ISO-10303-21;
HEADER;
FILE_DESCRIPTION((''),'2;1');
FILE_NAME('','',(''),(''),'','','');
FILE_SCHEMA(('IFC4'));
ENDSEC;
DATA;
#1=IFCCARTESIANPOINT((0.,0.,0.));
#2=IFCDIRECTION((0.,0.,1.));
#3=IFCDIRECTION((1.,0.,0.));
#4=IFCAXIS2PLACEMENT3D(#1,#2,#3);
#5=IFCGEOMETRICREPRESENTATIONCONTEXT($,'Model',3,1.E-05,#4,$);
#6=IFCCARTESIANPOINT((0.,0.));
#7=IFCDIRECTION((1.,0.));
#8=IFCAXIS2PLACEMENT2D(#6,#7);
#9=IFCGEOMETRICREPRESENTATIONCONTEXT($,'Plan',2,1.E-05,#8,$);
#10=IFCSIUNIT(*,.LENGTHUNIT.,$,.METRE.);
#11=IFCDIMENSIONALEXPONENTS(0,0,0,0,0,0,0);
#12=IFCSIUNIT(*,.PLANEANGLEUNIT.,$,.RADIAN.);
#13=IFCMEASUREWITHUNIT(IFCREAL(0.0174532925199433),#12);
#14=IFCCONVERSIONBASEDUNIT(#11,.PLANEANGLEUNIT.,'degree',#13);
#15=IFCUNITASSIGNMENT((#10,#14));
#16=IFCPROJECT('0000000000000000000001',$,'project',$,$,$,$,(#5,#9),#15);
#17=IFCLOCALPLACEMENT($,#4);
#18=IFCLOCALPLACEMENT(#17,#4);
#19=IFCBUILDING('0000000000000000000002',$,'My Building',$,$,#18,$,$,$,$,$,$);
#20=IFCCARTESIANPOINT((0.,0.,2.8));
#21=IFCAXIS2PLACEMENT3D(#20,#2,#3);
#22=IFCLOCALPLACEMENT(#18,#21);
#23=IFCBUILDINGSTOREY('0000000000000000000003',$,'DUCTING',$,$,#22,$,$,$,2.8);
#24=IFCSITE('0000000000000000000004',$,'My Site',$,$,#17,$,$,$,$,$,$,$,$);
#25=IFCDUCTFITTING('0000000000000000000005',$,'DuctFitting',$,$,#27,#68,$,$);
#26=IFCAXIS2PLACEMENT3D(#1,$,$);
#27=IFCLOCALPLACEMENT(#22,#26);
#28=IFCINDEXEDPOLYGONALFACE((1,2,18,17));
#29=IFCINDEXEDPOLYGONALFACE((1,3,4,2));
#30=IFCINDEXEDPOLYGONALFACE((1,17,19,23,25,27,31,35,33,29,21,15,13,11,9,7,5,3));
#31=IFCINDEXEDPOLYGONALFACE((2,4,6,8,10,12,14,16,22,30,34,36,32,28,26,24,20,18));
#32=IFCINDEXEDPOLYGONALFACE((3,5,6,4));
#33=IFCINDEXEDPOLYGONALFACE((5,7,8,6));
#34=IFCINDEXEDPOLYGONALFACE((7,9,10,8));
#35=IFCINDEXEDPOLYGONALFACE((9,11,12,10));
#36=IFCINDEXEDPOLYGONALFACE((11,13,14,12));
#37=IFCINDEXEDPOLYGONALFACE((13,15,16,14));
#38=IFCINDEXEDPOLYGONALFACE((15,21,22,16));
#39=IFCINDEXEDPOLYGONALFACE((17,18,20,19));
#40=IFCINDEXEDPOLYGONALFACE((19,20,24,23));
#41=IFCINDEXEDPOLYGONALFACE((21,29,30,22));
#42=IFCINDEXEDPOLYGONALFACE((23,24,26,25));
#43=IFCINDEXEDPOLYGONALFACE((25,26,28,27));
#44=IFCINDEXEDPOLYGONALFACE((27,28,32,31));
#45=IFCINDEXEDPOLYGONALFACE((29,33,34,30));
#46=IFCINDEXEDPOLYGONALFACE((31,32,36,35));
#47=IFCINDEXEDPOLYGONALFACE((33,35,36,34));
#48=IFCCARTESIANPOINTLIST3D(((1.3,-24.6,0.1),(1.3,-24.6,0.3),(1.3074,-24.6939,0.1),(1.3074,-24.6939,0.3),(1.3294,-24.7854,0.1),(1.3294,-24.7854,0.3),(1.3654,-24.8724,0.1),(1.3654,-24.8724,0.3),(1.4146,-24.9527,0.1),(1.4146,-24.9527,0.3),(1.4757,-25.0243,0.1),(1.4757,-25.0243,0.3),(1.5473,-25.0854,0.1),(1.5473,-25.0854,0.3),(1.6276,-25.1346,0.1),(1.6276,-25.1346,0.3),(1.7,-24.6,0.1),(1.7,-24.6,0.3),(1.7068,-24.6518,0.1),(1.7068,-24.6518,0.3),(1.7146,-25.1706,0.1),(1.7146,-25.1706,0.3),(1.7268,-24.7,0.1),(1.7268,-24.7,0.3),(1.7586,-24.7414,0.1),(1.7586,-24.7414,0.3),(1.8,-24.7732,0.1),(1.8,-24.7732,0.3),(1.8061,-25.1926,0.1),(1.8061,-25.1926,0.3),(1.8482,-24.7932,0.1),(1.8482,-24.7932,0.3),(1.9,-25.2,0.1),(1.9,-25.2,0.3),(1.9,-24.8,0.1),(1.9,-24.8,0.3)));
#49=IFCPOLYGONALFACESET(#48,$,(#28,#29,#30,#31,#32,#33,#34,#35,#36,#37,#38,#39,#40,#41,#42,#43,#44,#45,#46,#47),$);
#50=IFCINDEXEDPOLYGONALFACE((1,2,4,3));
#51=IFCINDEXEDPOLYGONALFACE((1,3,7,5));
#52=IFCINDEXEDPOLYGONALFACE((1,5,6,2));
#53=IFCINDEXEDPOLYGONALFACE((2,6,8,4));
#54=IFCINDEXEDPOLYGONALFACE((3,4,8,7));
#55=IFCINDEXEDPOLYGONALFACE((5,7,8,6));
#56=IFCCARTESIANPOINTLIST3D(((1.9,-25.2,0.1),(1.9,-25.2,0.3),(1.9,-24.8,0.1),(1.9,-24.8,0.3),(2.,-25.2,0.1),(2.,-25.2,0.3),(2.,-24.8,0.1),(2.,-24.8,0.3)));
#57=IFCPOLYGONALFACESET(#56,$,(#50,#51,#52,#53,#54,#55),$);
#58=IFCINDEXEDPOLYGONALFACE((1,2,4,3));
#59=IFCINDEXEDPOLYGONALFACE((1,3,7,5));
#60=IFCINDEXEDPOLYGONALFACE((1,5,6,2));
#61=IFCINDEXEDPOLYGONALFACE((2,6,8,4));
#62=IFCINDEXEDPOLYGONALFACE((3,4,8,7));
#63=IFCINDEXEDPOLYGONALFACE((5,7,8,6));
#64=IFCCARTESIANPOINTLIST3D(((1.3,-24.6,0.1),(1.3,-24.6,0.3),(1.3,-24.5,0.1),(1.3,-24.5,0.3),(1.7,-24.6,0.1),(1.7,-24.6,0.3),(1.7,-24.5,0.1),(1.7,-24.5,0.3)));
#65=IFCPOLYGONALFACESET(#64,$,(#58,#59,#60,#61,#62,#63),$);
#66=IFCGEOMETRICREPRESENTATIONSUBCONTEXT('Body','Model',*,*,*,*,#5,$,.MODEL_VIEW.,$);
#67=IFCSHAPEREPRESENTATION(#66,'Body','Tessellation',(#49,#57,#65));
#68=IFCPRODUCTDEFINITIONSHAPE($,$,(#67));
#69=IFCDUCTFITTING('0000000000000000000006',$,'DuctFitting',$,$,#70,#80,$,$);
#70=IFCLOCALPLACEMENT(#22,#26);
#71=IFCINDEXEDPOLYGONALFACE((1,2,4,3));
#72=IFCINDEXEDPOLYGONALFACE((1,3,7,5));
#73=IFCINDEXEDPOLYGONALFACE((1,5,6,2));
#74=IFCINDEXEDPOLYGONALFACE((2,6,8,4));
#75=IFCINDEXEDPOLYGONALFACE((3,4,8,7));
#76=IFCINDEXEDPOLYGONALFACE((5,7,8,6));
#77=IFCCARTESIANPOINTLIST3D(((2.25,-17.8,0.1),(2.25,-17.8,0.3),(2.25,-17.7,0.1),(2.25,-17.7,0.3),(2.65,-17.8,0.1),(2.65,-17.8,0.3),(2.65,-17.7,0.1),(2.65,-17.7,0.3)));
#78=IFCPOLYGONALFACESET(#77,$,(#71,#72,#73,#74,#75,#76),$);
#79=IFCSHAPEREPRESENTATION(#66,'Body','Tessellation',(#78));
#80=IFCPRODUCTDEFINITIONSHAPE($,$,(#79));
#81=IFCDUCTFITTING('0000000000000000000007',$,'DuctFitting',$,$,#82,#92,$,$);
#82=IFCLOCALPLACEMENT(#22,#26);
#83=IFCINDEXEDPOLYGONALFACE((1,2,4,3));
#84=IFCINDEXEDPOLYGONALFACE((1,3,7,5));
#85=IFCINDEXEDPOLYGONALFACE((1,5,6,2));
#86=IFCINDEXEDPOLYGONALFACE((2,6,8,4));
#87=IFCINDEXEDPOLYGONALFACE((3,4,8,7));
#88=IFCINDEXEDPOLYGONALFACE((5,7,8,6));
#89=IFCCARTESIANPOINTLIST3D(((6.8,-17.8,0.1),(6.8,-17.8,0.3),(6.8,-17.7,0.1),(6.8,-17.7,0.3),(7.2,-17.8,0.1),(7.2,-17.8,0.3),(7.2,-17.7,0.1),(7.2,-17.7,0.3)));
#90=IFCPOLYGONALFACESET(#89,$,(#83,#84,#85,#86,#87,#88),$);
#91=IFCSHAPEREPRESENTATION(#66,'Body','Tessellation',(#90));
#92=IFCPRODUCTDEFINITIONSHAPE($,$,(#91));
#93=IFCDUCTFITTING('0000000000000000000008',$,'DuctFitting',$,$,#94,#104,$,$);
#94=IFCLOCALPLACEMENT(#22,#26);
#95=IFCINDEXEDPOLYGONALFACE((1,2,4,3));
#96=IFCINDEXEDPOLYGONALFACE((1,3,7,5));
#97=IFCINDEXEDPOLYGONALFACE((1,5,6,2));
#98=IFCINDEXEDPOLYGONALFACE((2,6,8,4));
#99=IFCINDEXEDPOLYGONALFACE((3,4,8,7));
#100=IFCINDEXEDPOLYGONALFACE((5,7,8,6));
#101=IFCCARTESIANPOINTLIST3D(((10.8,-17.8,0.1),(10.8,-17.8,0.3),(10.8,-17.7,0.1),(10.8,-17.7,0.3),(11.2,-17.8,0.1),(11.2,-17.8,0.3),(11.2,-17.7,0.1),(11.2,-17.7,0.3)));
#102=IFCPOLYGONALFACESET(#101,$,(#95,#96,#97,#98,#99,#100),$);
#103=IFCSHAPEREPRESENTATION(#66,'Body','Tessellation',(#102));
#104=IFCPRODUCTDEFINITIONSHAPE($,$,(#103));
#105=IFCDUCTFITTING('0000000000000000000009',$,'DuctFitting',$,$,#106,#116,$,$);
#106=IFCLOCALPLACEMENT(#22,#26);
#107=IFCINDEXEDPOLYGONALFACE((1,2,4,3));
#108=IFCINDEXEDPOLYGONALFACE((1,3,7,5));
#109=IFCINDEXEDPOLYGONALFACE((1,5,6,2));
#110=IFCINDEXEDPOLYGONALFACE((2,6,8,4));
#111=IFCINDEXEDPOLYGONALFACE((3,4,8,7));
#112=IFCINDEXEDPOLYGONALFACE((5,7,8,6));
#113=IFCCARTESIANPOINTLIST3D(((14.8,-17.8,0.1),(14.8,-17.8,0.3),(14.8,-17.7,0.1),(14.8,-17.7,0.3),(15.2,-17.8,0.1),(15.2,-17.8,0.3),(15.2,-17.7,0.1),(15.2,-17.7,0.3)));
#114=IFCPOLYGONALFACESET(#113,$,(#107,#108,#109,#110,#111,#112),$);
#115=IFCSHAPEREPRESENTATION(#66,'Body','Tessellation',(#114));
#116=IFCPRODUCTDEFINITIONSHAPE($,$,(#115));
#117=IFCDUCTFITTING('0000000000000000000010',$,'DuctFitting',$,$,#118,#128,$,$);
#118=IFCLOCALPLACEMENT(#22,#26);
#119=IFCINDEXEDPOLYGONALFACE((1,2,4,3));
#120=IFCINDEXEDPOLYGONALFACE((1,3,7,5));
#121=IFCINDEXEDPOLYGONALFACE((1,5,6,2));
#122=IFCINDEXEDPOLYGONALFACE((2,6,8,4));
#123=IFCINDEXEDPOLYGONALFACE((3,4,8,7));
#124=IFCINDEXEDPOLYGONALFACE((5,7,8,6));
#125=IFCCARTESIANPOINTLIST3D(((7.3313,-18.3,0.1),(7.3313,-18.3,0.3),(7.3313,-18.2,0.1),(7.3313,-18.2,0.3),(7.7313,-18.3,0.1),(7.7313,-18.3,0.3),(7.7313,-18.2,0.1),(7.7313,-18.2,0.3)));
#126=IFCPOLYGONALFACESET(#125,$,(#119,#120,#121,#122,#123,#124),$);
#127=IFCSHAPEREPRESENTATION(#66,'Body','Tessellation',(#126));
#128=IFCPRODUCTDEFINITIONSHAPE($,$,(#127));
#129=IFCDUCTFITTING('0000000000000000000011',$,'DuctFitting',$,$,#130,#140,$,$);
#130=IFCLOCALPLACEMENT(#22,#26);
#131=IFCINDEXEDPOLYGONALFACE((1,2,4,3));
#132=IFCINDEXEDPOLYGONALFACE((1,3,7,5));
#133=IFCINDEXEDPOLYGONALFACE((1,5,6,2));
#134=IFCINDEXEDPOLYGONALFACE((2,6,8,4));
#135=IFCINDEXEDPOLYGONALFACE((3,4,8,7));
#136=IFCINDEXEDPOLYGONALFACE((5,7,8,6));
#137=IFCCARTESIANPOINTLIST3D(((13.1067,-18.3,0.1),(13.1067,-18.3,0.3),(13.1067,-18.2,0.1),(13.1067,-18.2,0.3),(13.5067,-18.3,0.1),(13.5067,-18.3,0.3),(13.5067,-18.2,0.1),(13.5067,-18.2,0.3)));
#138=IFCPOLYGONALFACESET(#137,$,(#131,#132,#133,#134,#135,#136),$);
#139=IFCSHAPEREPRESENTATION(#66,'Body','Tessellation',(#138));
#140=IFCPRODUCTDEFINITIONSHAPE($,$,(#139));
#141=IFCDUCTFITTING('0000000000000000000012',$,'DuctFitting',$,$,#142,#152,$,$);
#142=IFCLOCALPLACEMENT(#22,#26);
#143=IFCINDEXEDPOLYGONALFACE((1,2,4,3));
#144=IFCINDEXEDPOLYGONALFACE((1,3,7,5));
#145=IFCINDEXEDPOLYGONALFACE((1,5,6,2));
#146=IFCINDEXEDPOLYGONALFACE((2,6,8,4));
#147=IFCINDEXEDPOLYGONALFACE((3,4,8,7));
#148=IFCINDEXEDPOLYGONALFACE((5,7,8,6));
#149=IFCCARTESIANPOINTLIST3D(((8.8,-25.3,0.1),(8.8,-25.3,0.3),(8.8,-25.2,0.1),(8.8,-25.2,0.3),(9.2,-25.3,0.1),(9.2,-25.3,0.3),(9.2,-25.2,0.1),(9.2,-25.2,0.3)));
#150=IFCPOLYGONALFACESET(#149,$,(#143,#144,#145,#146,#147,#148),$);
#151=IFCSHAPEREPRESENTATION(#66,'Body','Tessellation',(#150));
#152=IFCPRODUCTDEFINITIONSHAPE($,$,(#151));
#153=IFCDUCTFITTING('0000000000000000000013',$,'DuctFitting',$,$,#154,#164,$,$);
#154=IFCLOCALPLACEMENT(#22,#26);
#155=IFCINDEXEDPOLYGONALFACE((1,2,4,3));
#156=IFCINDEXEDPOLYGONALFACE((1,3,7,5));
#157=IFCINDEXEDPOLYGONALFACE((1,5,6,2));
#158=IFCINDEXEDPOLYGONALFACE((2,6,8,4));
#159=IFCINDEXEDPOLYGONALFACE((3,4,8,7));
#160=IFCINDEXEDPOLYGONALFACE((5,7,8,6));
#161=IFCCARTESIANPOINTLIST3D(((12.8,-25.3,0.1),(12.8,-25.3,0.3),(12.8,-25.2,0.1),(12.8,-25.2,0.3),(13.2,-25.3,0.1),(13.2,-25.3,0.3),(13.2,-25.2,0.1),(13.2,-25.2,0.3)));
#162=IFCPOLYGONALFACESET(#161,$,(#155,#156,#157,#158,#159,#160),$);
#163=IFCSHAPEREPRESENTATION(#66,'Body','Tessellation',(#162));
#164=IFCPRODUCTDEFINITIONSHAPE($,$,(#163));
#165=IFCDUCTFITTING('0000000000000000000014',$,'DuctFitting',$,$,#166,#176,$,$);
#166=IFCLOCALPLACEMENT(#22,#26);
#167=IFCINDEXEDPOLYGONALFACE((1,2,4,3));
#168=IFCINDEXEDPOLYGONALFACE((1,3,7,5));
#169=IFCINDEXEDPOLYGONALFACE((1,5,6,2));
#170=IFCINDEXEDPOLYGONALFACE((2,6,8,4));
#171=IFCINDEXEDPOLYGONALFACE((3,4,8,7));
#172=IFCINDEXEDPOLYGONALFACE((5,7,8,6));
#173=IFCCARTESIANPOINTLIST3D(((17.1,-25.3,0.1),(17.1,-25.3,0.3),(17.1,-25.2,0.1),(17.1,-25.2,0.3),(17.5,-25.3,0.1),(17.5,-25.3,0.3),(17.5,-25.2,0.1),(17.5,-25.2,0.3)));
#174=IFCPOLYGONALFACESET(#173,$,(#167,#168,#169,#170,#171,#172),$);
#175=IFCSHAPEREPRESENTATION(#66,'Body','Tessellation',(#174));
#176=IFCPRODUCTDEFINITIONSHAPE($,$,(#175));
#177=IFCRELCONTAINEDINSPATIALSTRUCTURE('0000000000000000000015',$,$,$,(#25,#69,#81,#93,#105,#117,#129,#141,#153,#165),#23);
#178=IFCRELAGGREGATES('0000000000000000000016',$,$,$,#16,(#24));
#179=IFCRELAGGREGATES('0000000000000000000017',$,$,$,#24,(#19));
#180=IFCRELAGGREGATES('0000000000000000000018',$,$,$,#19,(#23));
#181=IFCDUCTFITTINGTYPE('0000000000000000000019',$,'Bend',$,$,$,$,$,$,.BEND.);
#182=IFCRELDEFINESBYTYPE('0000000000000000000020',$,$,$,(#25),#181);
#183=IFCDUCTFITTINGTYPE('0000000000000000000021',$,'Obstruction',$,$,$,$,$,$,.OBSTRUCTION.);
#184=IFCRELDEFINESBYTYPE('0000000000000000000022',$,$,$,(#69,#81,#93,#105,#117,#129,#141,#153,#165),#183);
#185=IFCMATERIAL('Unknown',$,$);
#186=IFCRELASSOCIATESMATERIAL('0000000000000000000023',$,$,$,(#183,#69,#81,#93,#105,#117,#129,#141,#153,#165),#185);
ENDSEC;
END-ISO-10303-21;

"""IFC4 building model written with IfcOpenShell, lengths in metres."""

from ifc_helpers import new_model, entity, si_unit, converted_unit, frame, origin_with_axes, origin_2d_with_axis, place, context, subcontext, project, spatial, line, arc, indexed_curve, rectangle, outline, extrude, source, transform, mapped, material, material_profile, profile_set, profile_usage, type_object, type_shapes, element, save


model = new_model("IFC4")

# Units and contexts
model_context = context("Model", 3, precision=1e-05, world=origin_with_axes())
plan_context = context("Plan", 2, precision=1e-05, world=origin_2d_with_axis())
body_context = subcontext(model_context, "Body", "Model", "MODEL_VIEW")
ifc_project = project(units=[si_unit("LENGTHUNIT", "METRE"), converted_unit("PLANEANGLEUNIT", "degree", entity("IfcReal", 0.0174532925199433), si_unit("PLANEANGLEUNIT", "RADIAN"), dimensions=[0, 0, 0, 0, 0, 0, 0])], contexts=[model_context, plan_context])

# Site, building, storey
site_placement = place(None, origin_with_axes())
site = spatial("IfcSite", under=ifc_project, at=site_placement, Name="My Site")
building_placement = place(site_placement, origin_with_axes())
building = spatial("IfcBuilding", under=site, at=building_placement, Name="My Building")
storey_placement = place(building_placement, frame((0.0, 0.0, 2.8), z_axis=(0.0, 0.0, 1.0), x_axis=(1.0, 0.0, 0.0)))
storey = spatial("IfcBuildingStorey", under=building, at=storey_placement, Name="DUCTING", Elevation=2.8)

# Shared definitions
ifc_material = material(Name="Unknown")
ifc_material_profile = material_profile(ifc_material, rectangle(XDim=0.4, YDim=0.2))
ifc_profile_set = profile_set([ifc_material_profile])

# Duct fittings
duct_fitting_type_1 = type_object("IfcDuctFittingType", Name="Bend", PredefinedType="BEND")
shared_shape = source(origin_with_axes(), body_context, "Body", "SweptSolid", [
    extrude(outline(indexed_curve([(-0.2, 0.0), (-0.2586, 0.1414), (-0.4, 0.2), (-0.4, 0.6), (0.0243, 0.4243), (0.2, 0.0)], segments=[arc(1, 2, 3), line(3, 4), arc(4, 5, 6), line(6, 1)])), frame((0.0, -0.1, 0.1), z_axis=(0.0, -1.0, 0.0), x_axis=(1.0, 0.0, 0.0)), (0.0, 0.0, -1.0), 0.2),
    extrude(rectangle(XDim=0.4, YDim=0.2), origin_with_axes(), (0.0, 0.0, 1.0), 0.1),
    extrude(rectangle(XDim=0.4, YDim=0.2), frame((-0.4, 0.0, 0.5), z_axis=(-1.0, 0.0, 0.0), x_axis=(0.0, 0.0, -1.0)), (0.0, 0.0, 1.0), 0.1),
])
type_shapes(duct_fitting_type_1, [shared_shape])
for number, where, z_axis, x_axis, name in (
    (1, (2.0, -25.0, 0.2), (-1.0, 0.0, 0.0), (0.0, -1.0, 0.0), "DuctFitting"),
):
    element("IfcDuctFitting", number, at=place(storey_placement, frame(where, z_axis=z_axis, x_axis=x_axis)), inside=storey, type_object=duct_fitting_type_1, Name=name, context=body_context, shape_type="MappedRepresentation", body=[
        mapped(shared_shape, transform((0.0, 0.0, 0.0), x_axis=(1.0, 0.0, 0.0), y_axis=(0.0, 1.0, 0.0), z_axis=(0.0, 0.0, 1.0), scale=1.0)),
    ])
ifc_profile_usage_1 = profile_usage(ifc_profile_set)
duct_fitting_type_2 = type_object("IfcDuctFittingType", Name="Obstruction", PredefinedType="OBSTRUCTION", material=ifc_profile_set)
duct_fitting_1_placement = place(storey_placement, frame((2.45, -17.8, 0.2), z_axis=(0.0, 1.0, 0.0), x_axis=(-1.0, 0.0, 0.0)))
element("IfcDuctFitting", 2, at=duct_fitting_1_placement, inside=storey, type_object=duct_fitting_type_2, material=ifc_profile_usage_1, Name="DuctFitting", context=body_context, shape_type="SweptSolid", body=[
    extrude(rectangle(XDim=0.4, YDim=0.2), origin_with_axes(), (0.0, 0.0, 1.0), 0.1),
])
ifc_profile_usage_2 = profile_usage(ifc_profile_set)
duct_fitting_2_placement = place(storey_placement, frame((7.0, -17.8, 0.2), z_axis=(0.0, 1.0, 0.0), x_axis=(-1.0, 0.0, 0.0)))
element("IfcDuctFitting", 3, at=duct_fitting_2_placement, inside=storey, type_object=duct_fitting_type_2, material=ifc_profile_usage_2, Name="DuctFitting", context=body_context, shape_type="SweptSolid", body=[
    extrude(rectangle(XDim=0.4, YDim=0.2), origin_with_axes(), (0.0, 0.0, 1.0), 0.1),
])
ifc_profile_usage_3 = profile_usage(ifc_profile_set)
duct_fitting_3_placement = place(storey_placement, frame((11.0, -17.8, 0.2), z_axis=(0.0, 1.0, 0.0), x_axis=(-1.0, 0.0, 0.0)))
element("IfcDuctFitting", 4, at=duct_fitting_3_placement, inside=storey, type_object=duct_fitting_type_2, material=ifc_profile_usage_3, Name="DuctFitting", context=body_context, shape_type="SweptSolid", body=[
    extrude(rectangle(XDim=0.4, YDim=0.2), origin_with_axes(), (0.0, 0.0, 1.0), 0.1),
])
ifc_profile_usage_4 = profile_usage(ifc_profile_set)
duct_fitting_4_placement = place(storey_placement, frame((15.0, -17.8, 0.2), z_axis=(0.0, 1.0, 0.0), x_axis=(-1.0, 0.0, 0.0)))
element("IfcDuctFitting", 5, at=duct_fitting_4_placement, inside=storey, type_object=duct_fitting_type_2, material=ifc_profile_usage_4, Name="DuctFitting", context=body_context, shape_type="SweptSolid", body=[
    extrude(rectangle(XDim=0.4, YDim=0.2), origin_with_axes(), (0.0, 0.0, 1.0), 0.1),
])
ifc_profile_usage_5 = profile_usage(ifc_profile_set)
duct_fitting_5_placement = place(storey_placement, frame((7.5313, -18.2, 0.2), z_axis=(0.0, -1.0, 0.0), x_axis=(1.0, 0.0, 0.0)))
element("IfcDuctFitting", 6, at=duct_fitting_5_placement, inside=storey, type_object=duct_fitting_type_2, material=ifc_profile_usage_5, Name="DuctFitting", context=body_context, shape_type="SweptSolid", body=[
    extrude(rectangle(XDim=0.4, YDim=0.2), origin_with_axes(), (0.0, 0.0, 1.0), 0.1),
])
ifc_profile_usage_6 = profile_usage(ifc_profile_set)
duct_fitting_6_placement = place(storey_placement, frame((13.3067, -18.2, 0.2), z_axis=(0.0, -1.0, 0.0), x_axis=(1.0, 0.0, 0.0)))
element("IfcDuctFitting", 7, at=duct_fitting_6_placement, inside=storey, type_object=duct_fitting_type_2, material=ifc_profile_usage_6, Name="DuctFitting", context=body_context, shape_type="SweptSolid", body=[
    extrude(rectangle(XDim=0.4, YDim=0.2), origin_with_axes(), (0.0, 0.0, 1.0), 0.1),
])
ifc_profile_usage_7 = profile_usage(ifc_profile_set)
duct_fitting_7_placement = place(storey_placement, frame((9.0, -25.2, 0.2), z_axis=(0.0, -1.0, 0.0), x_axis=(1.0, 0.0, 0.0)))
element("IfcDuctFitting", 8, at=duct_fitting_7_placement, inside=storey, type_object=duct_fitting_type_2, material=ifc_profile_usage_7, Name="DuctFitting", context=body_context, shape_type="SweptSolid", body=[
    extrude(rectangle(XDim=0.4, YDim=0.2), origin_with_axes(), (0.0, 0.0, 1.0), 0.1),
])
ifc_profile_usage_8 = profile_usage(ifc_profile_set)
duct_fitting_8_placement = place(storey_placement, frame((13.0, -25.2, 0.2), z_axis=(0.0, -1.0, 0.0), x_axis=(1.0, 0.0, 0.0)))
element("IfcDuctFitting", 9, at=duct_fitting_8_placement, inside=storey, type_object=duct_fitting_type_2, material=ifc_profile_usage_8, Name="DuctFitting", context=body_context, shape_type="SweptSolid", body=[
    extrude(rectangle(XDim=0.4, YDim=0.2), origin_with_axes(), (0.0, 0.0, 1.0), 0.1),
])
ifc_profile_usage_9 = profile_usage(ifc_profile_set)
duct_fitting_9_placement = place(storey_placement, frame((17.3, -25.2, 0.2), z_axis=(0.0, -1.0, 0.0), x_axis=(1.0, 0.0, 0.0)))
element("IfcDuctFitting", 10, at=duct_fitting_9_placement, inside=storey, type_object=duct_fitting_type_2, material=ifc_profile_usage_9, Name="DuctFitting", context=body_context, shape_type="SweptSolid", body=[
    extrude(rectangle(XDim=0.4, YDim=0.2), origin_with_axes(), (0.0, 0.0, 1.0), 0.1),
])

save(model, "model.ifc")
